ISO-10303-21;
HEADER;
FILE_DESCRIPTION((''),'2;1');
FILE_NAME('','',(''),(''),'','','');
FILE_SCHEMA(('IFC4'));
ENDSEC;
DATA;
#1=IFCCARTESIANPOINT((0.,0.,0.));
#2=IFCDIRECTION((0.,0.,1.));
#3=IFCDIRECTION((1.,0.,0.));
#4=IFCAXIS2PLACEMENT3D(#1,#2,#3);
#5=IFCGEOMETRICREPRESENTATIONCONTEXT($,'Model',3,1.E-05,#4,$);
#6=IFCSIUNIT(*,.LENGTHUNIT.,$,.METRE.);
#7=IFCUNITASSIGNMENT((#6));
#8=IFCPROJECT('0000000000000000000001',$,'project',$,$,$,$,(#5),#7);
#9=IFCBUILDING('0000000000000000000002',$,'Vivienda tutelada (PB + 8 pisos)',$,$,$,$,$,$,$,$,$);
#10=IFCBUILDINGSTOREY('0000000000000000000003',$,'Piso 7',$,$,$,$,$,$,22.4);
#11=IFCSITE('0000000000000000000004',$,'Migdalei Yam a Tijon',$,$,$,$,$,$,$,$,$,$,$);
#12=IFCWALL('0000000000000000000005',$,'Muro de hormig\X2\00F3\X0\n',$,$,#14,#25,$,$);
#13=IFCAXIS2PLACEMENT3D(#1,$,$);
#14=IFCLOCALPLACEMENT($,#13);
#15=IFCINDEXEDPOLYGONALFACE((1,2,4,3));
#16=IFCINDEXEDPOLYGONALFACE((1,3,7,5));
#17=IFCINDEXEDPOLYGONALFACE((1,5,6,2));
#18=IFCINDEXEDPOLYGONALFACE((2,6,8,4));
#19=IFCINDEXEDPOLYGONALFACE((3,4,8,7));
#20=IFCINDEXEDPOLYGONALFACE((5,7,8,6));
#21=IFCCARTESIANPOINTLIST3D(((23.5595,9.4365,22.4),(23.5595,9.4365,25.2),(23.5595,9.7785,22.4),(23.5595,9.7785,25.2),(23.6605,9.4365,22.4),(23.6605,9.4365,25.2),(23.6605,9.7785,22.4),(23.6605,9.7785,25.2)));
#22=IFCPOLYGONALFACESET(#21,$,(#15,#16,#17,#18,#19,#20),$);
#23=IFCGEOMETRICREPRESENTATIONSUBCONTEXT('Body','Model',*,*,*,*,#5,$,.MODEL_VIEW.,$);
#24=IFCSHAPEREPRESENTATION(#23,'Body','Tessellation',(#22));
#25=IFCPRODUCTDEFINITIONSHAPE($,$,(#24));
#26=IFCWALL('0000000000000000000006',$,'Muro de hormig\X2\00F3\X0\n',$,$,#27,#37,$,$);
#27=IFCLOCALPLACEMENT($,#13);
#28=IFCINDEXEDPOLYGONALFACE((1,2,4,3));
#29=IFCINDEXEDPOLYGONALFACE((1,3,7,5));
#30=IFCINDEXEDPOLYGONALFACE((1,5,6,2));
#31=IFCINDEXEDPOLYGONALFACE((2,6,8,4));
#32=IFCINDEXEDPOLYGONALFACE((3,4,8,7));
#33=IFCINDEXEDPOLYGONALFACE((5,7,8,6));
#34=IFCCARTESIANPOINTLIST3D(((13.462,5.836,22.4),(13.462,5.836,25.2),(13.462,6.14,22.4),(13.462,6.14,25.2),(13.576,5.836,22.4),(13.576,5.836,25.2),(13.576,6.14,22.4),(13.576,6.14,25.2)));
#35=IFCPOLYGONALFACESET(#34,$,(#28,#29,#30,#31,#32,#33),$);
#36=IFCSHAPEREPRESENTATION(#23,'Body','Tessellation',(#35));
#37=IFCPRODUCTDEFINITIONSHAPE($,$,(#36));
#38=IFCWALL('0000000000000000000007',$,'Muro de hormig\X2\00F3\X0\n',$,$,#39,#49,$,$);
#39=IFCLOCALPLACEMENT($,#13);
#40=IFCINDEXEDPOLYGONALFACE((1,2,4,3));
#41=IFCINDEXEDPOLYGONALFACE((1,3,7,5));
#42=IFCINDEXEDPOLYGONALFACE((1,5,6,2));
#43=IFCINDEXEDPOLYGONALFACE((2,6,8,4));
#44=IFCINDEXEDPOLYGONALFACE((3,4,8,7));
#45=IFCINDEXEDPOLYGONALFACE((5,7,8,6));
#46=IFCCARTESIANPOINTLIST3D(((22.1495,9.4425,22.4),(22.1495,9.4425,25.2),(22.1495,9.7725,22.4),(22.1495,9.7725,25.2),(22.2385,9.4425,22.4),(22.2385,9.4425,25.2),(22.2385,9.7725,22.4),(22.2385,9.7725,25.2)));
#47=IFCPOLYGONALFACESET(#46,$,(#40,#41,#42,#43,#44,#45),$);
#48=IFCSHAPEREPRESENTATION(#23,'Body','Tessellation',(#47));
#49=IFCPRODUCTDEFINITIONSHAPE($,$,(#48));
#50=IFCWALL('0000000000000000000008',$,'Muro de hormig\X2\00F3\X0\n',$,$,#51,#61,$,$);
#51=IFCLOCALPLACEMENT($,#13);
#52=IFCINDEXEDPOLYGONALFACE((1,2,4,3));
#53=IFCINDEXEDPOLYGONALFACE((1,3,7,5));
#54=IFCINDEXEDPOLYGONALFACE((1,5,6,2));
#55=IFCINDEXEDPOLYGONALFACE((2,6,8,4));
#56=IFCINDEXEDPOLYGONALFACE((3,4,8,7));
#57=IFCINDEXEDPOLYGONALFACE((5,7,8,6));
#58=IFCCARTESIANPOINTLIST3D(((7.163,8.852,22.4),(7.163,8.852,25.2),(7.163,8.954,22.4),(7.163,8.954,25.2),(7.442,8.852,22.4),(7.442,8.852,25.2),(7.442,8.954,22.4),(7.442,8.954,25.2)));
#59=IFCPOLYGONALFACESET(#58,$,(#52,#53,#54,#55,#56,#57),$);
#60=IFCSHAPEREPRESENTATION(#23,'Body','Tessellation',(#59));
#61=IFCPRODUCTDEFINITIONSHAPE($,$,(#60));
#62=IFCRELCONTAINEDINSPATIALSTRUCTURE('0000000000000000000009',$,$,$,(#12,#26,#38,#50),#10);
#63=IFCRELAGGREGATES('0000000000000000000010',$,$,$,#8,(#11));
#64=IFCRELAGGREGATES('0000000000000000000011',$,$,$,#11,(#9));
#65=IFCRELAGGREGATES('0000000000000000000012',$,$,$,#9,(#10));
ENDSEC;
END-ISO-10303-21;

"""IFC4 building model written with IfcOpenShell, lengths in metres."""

from ifc_helpers import new_model, si_unit, frame, origin_with_axes, context, subcontext, project, spatial, line, indexed_curve, outline, extrude, element, save


model = new_model("IFC4")

# Units and contexts
model_context = context("Model", 3, precision=1e-05, world=origin_with_axes())
body_context = subcontext(model_context, "Body", "Model", "MODEL_VIEW")
ifc_project = project(units=[si_unit("LENGTHUNIT", "METRE")], contexts=[model_context])

# Site, building, storey
site = spatial("IfcSite", under=ifc_project, Name="Migdalei Yam a Tijon")
building = spatial("IfcBuilding", under=site, Name="Vivienda tutelada (PB + 8 pisos)")
storey = spatial("IfcBuildingStorey", under=building, Name="Piso 7", Elevation=22.4)

# Walls
element("IfcWall", 1, inside=storey, Name="Muro de hormigón", context=body_context, shape_type="SweptSolid", body=[
    extrude(outline(indexed_curve([(0.0, 0.0), (0.101, 0.0), (0.101, 0.342), (0.0, 0.342)], segments=[line(1, 2, 3, 4, 1)])), frame((23.5595, 9.4365, 22.4), z_axis=(0.0, 0.0, 1.0), x_axis=(1.0, 0.0, 0.0)), (0.0, 0.0, 1.0), 2.8),
])
element("IfcWall", 2, inside=storey, Name="Muro de hormigón", context=body_context, shape_type="SweptSolid", body=[
    extrude(outline(indexed_curve([(0.0, 0.0), (0.114, 0.0), (0.114, 0.304), (0.0, 0.304)], segments=[line(1, 2, 3, 4, 1)])), frame((13.462, 5.836, 22.4), z_axis=(0.0, 0.0, 1.0), x_axis=(1.0, 0.0, 0.0)), (0.0, 0.0, 1.0), 2.8),
])
element("IfcWall", 3, inside=storey, Name="Muro de hormigón", context=body_context, shape_type="SweptSolid", body=[
    extrude(outline(indexed_curve([(0.0, 0.0), (0.089, 0.0), (0.089, 0.33), (0.0, 0.33)], segments=[line(1, 2, 3, 4, 1)])), frame((22.1495, 9.4425, 22.4), z_axis=(0.0, 0.0, 1.0), x_axis=(1.0, 0.0, 0.0)), (0.0, 0.0, 1.0), 2.8),
])
element("IfcWall", 4, inside=storey, Name="Muro de hormigón", context=body_context, shape_type="SweptSolid", body=[
    extrude(outline(indexed_curve([(0.0, 0.0), (0.279, 0.0), (0.279, 0.102), (0.0, 0.102)], segments=[line(1, 2, 3, 4, 1)])), frame((7.163, 8.852, 22.4), z_axis=(0.0, 0.0, 1.0), x_axis=(1.0, 0.0, 0.0)), (0.0, 0.0, 1.0), 2.8),
])

save(model, "model.ifc")
